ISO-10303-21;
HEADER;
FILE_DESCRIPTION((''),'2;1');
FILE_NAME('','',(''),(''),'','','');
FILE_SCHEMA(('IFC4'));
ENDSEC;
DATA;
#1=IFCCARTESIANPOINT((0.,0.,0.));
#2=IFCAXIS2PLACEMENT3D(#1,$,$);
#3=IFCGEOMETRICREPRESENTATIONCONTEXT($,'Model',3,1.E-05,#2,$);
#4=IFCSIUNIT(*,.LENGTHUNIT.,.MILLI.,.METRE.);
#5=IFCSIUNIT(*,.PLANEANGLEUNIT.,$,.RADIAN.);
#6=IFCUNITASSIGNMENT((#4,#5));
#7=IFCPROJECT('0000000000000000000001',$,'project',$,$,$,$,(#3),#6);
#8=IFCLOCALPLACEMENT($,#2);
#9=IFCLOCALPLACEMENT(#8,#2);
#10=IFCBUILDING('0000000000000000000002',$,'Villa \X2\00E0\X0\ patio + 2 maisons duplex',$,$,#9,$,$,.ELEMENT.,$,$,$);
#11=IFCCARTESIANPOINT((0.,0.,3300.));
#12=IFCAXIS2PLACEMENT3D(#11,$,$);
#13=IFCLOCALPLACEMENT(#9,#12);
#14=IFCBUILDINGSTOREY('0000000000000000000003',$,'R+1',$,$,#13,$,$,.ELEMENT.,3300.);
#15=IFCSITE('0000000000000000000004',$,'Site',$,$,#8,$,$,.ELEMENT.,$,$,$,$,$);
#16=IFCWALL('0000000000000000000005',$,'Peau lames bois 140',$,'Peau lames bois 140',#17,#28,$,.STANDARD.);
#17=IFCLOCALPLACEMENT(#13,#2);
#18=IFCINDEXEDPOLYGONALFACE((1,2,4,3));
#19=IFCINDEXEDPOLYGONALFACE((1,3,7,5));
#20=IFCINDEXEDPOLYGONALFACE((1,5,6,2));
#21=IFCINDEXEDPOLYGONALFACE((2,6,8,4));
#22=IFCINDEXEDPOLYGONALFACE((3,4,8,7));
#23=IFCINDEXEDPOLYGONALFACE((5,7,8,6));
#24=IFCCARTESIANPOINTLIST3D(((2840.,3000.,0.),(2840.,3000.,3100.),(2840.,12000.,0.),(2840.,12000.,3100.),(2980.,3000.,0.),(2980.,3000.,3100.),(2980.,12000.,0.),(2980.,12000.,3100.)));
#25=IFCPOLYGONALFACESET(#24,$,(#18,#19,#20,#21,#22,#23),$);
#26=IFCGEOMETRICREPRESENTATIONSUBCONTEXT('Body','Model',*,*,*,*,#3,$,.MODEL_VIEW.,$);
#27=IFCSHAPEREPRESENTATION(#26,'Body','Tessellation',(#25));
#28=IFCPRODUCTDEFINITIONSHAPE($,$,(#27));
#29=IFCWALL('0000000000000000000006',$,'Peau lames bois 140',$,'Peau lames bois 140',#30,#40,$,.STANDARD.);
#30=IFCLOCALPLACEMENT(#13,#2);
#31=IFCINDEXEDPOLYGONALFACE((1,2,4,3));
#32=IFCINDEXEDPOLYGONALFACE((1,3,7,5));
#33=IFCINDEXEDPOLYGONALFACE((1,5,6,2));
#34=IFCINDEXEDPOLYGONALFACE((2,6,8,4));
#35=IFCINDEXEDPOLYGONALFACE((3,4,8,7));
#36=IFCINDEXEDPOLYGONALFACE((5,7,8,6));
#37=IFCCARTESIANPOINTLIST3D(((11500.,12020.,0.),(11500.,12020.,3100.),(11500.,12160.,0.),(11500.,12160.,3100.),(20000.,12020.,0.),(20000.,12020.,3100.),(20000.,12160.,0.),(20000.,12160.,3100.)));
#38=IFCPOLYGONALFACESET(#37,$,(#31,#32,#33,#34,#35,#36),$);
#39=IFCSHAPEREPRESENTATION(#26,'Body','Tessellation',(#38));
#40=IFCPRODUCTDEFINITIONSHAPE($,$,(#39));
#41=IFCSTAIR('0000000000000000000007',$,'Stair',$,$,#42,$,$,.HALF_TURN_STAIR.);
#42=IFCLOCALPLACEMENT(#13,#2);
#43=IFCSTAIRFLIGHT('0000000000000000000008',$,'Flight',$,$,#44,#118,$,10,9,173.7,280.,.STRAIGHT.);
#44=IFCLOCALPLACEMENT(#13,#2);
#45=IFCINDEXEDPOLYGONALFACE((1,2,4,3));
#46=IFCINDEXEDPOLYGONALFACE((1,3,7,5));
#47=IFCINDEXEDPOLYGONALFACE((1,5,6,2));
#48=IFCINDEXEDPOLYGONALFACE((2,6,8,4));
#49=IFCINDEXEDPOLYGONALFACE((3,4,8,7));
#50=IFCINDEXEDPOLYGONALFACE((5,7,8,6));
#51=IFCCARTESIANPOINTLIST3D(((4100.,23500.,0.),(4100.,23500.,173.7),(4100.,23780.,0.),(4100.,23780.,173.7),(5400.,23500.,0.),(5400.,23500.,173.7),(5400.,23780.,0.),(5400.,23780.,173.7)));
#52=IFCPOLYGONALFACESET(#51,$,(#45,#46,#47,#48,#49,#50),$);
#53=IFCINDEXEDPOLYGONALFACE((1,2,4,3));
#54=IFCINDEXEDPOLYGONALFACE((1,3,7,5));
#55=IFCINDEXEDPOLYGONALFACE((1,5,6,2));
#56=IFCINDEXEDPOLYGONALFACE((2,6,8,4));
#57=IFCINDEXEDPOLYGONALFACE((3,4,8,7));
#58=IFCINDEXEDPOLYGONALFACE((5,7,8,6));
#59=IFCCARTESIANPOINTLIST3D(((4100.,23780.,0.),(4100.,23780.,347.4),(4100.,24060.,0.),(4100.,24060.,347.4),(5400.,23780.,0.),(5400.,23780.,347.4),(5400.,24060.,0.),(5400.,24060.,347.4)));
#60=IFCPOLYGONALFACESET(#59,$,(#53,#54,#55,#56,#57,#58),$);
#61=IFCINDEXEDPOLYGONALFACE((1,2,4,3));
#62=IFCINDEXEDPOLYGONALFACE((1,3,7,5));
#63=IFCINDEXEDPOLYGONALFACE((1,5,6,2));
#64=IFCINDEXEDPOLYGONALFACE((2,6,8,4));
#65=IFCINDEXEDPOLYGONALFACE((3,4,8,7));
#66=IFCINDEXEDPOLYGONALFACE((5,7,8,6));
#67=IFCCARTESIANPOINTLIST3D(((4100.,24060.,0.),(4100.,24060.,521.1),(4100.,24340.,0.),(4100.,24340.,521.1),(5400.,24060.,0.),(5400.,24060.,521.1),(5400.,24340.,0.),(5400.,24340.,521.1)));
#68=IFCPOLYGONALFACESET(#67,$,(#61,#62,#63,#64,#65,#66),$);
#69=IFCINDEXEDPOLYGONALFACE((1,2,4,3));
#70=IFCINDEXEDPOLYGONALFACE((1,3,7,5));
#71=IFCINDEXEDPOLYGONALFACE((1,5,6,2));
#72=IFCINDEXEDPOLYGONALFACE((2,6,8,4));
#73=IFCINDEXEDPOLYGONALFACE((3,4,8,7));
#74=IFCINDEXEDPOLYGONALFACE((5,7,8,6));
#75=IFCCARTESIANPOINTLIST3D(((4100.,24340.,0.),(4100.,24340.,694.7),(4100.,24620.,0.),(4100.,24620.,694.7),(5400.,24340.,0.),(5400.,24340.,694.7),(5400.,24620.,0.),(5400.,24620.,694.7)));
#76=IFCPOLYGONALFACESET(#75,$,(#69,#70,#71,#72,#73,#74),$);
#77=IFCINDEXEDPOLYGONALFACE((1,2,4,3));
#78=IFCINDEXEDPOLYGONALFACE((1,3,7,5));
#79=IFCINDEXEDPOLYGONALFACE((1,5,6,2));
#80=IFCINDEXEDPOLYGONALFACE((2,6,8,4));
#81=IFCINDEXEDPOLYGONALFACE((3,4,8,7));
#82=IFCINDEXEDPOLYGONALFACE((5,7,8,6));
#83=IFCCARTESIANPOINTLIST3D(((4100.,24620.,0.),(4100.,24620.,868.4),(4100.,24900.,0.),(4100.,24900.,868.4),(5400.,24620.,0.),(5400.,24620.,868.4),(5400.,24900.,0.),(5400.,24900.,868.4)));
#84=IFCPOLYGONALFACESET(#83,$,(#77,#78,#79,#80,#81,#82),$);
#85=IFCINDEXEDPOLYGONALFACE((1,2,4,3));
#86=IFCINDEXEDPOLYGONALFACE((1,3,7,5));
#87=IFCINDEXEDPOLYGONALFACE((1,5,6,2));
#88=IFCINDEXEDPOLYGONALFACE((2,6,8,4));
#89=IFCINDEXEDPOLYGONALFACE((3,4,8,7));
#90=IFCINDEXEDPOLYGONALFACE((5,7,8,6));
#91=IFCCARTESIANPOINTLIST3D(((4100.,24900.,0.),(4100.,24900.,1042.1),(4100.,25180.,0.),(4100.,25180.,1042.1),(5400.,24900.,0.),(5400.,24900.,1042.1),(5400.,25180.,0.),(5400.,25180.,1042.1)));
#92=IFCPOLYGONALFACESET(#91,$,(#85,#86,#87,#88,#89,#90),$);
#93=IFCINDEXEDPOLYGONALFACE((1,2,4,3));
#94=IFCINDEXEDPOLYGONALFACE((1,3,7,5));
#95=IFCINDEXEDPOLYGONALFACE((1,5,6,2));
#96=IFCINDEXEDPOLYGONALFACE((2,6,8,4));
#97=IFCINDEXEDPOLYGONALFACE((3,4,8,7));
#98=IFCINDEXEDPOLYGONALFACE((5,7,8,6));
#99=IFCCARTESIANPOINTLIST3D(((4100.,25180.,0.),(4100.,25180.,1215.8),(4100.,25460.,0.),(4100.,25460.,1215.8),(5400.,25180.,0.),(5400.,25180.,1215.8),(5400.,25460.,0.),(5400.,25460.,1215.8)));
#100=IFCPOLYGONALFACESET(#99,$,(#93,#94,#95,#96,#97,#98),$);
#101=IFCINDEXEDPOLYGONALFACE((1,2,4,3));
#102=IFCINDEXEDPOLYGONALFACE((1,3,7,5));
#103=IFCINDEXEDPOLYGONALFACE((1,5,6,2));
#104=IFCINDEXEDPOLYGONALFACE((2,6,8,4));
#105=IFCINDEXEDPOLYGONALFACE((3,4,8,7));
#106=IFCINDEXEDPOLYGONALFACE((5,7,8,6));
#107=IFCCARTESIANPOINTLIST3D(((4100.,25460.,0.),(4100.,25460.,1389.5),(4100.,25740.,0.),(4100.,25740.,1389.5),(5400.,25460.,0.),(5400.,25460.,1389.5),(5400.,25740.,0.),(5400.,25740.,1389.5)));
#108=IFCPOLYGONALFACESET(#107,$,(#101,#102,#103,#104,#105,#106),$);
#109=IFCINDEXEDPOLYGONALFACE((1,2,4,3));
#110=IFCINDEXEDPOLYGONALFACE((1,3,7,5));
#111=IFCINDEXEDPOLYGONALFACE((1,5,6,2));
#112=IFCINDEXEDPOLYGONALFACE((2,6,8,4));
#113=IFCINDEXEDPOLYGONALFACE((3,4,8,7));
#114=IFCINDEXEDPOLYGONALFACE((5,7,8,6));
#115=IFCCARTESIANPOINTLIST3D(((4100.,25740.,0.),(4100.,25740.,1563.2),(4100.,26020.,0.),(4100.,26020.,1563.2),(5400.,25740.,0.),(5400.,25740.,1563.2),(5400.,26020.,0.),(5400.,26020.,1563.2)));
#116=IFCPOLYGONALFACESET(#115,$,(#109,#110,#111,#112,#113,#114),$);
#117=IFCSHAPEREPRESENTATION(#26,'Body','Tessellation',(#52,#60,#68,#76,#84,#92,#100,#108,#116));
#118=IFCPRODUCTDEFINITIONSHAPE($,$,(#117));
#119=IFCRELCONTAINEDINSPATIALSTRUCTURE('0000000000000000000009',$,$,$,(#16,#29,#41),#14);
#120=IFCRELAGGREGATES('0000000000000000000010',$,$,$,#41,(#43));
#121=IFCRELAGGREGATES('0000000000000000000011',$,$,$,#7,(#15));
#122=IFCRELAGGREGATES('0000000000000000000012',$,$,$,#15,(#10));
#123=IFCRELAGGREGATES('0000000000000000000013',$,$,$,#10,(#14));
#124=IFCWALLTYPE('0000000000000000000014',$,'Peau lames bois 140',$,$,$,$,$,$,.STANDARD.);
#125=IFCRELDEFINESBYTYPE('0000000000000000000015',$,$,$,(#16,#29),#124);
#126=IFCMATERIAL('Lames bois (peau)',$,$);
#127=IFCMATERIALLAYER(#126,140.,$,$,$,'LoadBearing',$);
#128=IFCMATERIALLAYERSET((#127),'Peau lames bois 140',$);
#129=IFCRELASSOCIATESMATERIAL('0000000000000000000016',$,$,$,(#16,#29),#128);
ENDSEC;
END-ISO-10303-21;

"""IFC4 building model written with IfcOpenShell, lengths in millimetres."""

from ifc_helpers import new_model, si_unit, frame, frame_2d, origin, place, context, subcontext, project, spatial, polyline, rectangle, outline, extrude, material, layer, layer_set, layer_usage, type_object, element, aggregate, save


model = new_model("IFC4")

# Units and contexts
model_context = context("Model", 3, precision=1e-05, world=origin())
body_context = subcontext(model_context, "Body", "Model", "MODEL_VIEW")
ifc_project = project(units=[si_unit("LENGTHUNIT", "METRE", prefix="MILLI"), si_unit("PLANEANGLEUNIT", "RADIAN")], contexts=[model_context])

# Site, building, storey
site_placement = place(None, origin())
site = spatial("IfcSite", under=ifc_project, at=site_placement, Name="Site", CompositionType="ELEMENT")
building_placement = place(site_placement, origin())
building = spatial("IfcBuilding", under=site, at=building_placement, Name="Villa à patio + 2 maisons duplex", CompositionType="ELEMENT")
storey_placement = place(building_placement, frame((0.0, 0.0, 3300.0)))
storey = spatial("IfcBuildingStorey", under=building, at=storey_placement, Name="R+1", CompositionType="ELEMENT", Elevation=3300.0)

# Walls
ifc_material_1 = material(Name="Lames bois (peau)")
ifc_layer_1 = layer(ifc_material_1, 140.0, Category="LoadBearing")
ifc_layer_set_1 = layer_set([ifc_layer_1], Name="Peau lames bois 140")
ifc_layer_usage_1 = layer_usage(ifc_layer_set_1, "AXIS2", "NEGATIVE", 70.0)
wall_type_1 = type_object("IfcWallType", Name="Peau lames bois 140", PredefinedType="STANDARD")
wall_1_placement = place(storey_placement, frame((2910.0, 12000.0, 0.0), z_axis=(0.0, 0.0, 1.0), x_axis=(0.0, -1.0, 0.0)))
element("IfcWall", 1, at=wall_1_placement, inside=storey, type_object=wall_type_1, material=ifc_layer_usage_1, Name="Peau lames bois 140", ObjectType="Peau lames bois 140", PredefinedType="STANDARD", context=body_context, shape_type="SweptSolid", body=[
    extrude(outline(polyline([(0.0, -70.0), (0.0, 70.0), (9000.0, 70.0), (9000.0, -70.0), (0.0, -70.0)])), origin(), (0.0, 0.0, 1.0), 3100.0),
])
wall_2_placement = place(storey_placement, frame((11500.0, 12090.0, 0.0), z_axis=(0.0, 0.0, 1.0), x_axis=(1.0, 0.0, 0.0)))
element("IfcWall", 2, at=wall_2_placement, inside=storey, type_object=wall_type_1, material=ifc_layer_usage_1, Name="Peau lames bois 140", ObjectType="Peau lames bois 140", PredefinedType="STANDARD", context=body_context, shape_type="SweptSolid", body=[
    extrude(outline(polyline([(0.0, -70.0), (0.0, 70.0), (8500.0, 70.0), (8500.0, -70.0), (0.0, -70.0)])), origin(), (0.0, 0.0, 1.0), 3100.0),
])

# Stair, stair flight
stair_placement = place(storey_placement, origin())
stair = element("IfcStair", 3, at=stair_placement, inside=storey, Name="Stair", PredefinedType="HALF_TURN_STAIR")
stair_flight_placement = place(stair_placement, frame((4750.0, 23500.0, 0.0), z_axis=(0.0, 0.0, 1.0), x_axis=(0.0, 1.0, 0.0)))
stair_flight = element("IfcStairFlight", 4, at=stair_flight_placement, Name="Flight", NumberOfRisers=10, NumberOfTreads=9, PredefinedType="STRAIGHT", RiserHeight=173.7, TreadLength=280.0, context=body_context, shape_type="SweptSolid", body=[
    extrude(rectangle(XDim=280.0, YDim=1300.0, at=frame_2d((140.0, 0.0))), origin(), (0.0, 0.0, 1.0), 173.7),
    extrude(rectangle(XDim=280.0, YDim=1300.0, at=frame_2d((420.0, 0.0))), origin(), (0.0, 0.0, 1.0), 347.4),
    extrude(rectangle(XDim=280.0, YDim=1300.0, at=frame_2d((700.0, 0.0))), origin(), (0.0, 0.0, 1.0), 521.1),
    extrude(rectangle(XDim=280.0, YDim=1300.0, at=frame_2d((980.0, 0.0))), origin(), (0.0, 0.0, 1.0), 694.7),
    extrude(rectangle(XDim=280.0, YDim=1300.0, at=frame_2d((1260.0, 0.0))), origin(), (0.0, 0.0, 1.0), 868.4),
    extrude(rectangle(XDim=280.0, YDim=1300.0, at=frame_2d((1540.0, 0.0))), origin(), (0.0, 0.0, 1.0), 1042.1),
    extrude(rectangle(XDim=280.0, YDim=1300.0, at=frame_2d((1820.0, 0.0))), origin(), (0.0, 0.0, 1.0), 1215.8),
    extrude(rectangle(XDim=280.0, YDim=1300.0, at=frame_2d((2100.0, 0.0))), origin(), (0.0, 0.0, 1.0), 1389.5),
    extrude(rectangle(XDim=280.0, YDim=1300.0, at=frame_2d((2380.0, 0.0))), origin(), (0.0, 0.0, 1.0), 1563.2),
])
aggregate(stair, [stair_flight])

save(model, "model.ifc")
